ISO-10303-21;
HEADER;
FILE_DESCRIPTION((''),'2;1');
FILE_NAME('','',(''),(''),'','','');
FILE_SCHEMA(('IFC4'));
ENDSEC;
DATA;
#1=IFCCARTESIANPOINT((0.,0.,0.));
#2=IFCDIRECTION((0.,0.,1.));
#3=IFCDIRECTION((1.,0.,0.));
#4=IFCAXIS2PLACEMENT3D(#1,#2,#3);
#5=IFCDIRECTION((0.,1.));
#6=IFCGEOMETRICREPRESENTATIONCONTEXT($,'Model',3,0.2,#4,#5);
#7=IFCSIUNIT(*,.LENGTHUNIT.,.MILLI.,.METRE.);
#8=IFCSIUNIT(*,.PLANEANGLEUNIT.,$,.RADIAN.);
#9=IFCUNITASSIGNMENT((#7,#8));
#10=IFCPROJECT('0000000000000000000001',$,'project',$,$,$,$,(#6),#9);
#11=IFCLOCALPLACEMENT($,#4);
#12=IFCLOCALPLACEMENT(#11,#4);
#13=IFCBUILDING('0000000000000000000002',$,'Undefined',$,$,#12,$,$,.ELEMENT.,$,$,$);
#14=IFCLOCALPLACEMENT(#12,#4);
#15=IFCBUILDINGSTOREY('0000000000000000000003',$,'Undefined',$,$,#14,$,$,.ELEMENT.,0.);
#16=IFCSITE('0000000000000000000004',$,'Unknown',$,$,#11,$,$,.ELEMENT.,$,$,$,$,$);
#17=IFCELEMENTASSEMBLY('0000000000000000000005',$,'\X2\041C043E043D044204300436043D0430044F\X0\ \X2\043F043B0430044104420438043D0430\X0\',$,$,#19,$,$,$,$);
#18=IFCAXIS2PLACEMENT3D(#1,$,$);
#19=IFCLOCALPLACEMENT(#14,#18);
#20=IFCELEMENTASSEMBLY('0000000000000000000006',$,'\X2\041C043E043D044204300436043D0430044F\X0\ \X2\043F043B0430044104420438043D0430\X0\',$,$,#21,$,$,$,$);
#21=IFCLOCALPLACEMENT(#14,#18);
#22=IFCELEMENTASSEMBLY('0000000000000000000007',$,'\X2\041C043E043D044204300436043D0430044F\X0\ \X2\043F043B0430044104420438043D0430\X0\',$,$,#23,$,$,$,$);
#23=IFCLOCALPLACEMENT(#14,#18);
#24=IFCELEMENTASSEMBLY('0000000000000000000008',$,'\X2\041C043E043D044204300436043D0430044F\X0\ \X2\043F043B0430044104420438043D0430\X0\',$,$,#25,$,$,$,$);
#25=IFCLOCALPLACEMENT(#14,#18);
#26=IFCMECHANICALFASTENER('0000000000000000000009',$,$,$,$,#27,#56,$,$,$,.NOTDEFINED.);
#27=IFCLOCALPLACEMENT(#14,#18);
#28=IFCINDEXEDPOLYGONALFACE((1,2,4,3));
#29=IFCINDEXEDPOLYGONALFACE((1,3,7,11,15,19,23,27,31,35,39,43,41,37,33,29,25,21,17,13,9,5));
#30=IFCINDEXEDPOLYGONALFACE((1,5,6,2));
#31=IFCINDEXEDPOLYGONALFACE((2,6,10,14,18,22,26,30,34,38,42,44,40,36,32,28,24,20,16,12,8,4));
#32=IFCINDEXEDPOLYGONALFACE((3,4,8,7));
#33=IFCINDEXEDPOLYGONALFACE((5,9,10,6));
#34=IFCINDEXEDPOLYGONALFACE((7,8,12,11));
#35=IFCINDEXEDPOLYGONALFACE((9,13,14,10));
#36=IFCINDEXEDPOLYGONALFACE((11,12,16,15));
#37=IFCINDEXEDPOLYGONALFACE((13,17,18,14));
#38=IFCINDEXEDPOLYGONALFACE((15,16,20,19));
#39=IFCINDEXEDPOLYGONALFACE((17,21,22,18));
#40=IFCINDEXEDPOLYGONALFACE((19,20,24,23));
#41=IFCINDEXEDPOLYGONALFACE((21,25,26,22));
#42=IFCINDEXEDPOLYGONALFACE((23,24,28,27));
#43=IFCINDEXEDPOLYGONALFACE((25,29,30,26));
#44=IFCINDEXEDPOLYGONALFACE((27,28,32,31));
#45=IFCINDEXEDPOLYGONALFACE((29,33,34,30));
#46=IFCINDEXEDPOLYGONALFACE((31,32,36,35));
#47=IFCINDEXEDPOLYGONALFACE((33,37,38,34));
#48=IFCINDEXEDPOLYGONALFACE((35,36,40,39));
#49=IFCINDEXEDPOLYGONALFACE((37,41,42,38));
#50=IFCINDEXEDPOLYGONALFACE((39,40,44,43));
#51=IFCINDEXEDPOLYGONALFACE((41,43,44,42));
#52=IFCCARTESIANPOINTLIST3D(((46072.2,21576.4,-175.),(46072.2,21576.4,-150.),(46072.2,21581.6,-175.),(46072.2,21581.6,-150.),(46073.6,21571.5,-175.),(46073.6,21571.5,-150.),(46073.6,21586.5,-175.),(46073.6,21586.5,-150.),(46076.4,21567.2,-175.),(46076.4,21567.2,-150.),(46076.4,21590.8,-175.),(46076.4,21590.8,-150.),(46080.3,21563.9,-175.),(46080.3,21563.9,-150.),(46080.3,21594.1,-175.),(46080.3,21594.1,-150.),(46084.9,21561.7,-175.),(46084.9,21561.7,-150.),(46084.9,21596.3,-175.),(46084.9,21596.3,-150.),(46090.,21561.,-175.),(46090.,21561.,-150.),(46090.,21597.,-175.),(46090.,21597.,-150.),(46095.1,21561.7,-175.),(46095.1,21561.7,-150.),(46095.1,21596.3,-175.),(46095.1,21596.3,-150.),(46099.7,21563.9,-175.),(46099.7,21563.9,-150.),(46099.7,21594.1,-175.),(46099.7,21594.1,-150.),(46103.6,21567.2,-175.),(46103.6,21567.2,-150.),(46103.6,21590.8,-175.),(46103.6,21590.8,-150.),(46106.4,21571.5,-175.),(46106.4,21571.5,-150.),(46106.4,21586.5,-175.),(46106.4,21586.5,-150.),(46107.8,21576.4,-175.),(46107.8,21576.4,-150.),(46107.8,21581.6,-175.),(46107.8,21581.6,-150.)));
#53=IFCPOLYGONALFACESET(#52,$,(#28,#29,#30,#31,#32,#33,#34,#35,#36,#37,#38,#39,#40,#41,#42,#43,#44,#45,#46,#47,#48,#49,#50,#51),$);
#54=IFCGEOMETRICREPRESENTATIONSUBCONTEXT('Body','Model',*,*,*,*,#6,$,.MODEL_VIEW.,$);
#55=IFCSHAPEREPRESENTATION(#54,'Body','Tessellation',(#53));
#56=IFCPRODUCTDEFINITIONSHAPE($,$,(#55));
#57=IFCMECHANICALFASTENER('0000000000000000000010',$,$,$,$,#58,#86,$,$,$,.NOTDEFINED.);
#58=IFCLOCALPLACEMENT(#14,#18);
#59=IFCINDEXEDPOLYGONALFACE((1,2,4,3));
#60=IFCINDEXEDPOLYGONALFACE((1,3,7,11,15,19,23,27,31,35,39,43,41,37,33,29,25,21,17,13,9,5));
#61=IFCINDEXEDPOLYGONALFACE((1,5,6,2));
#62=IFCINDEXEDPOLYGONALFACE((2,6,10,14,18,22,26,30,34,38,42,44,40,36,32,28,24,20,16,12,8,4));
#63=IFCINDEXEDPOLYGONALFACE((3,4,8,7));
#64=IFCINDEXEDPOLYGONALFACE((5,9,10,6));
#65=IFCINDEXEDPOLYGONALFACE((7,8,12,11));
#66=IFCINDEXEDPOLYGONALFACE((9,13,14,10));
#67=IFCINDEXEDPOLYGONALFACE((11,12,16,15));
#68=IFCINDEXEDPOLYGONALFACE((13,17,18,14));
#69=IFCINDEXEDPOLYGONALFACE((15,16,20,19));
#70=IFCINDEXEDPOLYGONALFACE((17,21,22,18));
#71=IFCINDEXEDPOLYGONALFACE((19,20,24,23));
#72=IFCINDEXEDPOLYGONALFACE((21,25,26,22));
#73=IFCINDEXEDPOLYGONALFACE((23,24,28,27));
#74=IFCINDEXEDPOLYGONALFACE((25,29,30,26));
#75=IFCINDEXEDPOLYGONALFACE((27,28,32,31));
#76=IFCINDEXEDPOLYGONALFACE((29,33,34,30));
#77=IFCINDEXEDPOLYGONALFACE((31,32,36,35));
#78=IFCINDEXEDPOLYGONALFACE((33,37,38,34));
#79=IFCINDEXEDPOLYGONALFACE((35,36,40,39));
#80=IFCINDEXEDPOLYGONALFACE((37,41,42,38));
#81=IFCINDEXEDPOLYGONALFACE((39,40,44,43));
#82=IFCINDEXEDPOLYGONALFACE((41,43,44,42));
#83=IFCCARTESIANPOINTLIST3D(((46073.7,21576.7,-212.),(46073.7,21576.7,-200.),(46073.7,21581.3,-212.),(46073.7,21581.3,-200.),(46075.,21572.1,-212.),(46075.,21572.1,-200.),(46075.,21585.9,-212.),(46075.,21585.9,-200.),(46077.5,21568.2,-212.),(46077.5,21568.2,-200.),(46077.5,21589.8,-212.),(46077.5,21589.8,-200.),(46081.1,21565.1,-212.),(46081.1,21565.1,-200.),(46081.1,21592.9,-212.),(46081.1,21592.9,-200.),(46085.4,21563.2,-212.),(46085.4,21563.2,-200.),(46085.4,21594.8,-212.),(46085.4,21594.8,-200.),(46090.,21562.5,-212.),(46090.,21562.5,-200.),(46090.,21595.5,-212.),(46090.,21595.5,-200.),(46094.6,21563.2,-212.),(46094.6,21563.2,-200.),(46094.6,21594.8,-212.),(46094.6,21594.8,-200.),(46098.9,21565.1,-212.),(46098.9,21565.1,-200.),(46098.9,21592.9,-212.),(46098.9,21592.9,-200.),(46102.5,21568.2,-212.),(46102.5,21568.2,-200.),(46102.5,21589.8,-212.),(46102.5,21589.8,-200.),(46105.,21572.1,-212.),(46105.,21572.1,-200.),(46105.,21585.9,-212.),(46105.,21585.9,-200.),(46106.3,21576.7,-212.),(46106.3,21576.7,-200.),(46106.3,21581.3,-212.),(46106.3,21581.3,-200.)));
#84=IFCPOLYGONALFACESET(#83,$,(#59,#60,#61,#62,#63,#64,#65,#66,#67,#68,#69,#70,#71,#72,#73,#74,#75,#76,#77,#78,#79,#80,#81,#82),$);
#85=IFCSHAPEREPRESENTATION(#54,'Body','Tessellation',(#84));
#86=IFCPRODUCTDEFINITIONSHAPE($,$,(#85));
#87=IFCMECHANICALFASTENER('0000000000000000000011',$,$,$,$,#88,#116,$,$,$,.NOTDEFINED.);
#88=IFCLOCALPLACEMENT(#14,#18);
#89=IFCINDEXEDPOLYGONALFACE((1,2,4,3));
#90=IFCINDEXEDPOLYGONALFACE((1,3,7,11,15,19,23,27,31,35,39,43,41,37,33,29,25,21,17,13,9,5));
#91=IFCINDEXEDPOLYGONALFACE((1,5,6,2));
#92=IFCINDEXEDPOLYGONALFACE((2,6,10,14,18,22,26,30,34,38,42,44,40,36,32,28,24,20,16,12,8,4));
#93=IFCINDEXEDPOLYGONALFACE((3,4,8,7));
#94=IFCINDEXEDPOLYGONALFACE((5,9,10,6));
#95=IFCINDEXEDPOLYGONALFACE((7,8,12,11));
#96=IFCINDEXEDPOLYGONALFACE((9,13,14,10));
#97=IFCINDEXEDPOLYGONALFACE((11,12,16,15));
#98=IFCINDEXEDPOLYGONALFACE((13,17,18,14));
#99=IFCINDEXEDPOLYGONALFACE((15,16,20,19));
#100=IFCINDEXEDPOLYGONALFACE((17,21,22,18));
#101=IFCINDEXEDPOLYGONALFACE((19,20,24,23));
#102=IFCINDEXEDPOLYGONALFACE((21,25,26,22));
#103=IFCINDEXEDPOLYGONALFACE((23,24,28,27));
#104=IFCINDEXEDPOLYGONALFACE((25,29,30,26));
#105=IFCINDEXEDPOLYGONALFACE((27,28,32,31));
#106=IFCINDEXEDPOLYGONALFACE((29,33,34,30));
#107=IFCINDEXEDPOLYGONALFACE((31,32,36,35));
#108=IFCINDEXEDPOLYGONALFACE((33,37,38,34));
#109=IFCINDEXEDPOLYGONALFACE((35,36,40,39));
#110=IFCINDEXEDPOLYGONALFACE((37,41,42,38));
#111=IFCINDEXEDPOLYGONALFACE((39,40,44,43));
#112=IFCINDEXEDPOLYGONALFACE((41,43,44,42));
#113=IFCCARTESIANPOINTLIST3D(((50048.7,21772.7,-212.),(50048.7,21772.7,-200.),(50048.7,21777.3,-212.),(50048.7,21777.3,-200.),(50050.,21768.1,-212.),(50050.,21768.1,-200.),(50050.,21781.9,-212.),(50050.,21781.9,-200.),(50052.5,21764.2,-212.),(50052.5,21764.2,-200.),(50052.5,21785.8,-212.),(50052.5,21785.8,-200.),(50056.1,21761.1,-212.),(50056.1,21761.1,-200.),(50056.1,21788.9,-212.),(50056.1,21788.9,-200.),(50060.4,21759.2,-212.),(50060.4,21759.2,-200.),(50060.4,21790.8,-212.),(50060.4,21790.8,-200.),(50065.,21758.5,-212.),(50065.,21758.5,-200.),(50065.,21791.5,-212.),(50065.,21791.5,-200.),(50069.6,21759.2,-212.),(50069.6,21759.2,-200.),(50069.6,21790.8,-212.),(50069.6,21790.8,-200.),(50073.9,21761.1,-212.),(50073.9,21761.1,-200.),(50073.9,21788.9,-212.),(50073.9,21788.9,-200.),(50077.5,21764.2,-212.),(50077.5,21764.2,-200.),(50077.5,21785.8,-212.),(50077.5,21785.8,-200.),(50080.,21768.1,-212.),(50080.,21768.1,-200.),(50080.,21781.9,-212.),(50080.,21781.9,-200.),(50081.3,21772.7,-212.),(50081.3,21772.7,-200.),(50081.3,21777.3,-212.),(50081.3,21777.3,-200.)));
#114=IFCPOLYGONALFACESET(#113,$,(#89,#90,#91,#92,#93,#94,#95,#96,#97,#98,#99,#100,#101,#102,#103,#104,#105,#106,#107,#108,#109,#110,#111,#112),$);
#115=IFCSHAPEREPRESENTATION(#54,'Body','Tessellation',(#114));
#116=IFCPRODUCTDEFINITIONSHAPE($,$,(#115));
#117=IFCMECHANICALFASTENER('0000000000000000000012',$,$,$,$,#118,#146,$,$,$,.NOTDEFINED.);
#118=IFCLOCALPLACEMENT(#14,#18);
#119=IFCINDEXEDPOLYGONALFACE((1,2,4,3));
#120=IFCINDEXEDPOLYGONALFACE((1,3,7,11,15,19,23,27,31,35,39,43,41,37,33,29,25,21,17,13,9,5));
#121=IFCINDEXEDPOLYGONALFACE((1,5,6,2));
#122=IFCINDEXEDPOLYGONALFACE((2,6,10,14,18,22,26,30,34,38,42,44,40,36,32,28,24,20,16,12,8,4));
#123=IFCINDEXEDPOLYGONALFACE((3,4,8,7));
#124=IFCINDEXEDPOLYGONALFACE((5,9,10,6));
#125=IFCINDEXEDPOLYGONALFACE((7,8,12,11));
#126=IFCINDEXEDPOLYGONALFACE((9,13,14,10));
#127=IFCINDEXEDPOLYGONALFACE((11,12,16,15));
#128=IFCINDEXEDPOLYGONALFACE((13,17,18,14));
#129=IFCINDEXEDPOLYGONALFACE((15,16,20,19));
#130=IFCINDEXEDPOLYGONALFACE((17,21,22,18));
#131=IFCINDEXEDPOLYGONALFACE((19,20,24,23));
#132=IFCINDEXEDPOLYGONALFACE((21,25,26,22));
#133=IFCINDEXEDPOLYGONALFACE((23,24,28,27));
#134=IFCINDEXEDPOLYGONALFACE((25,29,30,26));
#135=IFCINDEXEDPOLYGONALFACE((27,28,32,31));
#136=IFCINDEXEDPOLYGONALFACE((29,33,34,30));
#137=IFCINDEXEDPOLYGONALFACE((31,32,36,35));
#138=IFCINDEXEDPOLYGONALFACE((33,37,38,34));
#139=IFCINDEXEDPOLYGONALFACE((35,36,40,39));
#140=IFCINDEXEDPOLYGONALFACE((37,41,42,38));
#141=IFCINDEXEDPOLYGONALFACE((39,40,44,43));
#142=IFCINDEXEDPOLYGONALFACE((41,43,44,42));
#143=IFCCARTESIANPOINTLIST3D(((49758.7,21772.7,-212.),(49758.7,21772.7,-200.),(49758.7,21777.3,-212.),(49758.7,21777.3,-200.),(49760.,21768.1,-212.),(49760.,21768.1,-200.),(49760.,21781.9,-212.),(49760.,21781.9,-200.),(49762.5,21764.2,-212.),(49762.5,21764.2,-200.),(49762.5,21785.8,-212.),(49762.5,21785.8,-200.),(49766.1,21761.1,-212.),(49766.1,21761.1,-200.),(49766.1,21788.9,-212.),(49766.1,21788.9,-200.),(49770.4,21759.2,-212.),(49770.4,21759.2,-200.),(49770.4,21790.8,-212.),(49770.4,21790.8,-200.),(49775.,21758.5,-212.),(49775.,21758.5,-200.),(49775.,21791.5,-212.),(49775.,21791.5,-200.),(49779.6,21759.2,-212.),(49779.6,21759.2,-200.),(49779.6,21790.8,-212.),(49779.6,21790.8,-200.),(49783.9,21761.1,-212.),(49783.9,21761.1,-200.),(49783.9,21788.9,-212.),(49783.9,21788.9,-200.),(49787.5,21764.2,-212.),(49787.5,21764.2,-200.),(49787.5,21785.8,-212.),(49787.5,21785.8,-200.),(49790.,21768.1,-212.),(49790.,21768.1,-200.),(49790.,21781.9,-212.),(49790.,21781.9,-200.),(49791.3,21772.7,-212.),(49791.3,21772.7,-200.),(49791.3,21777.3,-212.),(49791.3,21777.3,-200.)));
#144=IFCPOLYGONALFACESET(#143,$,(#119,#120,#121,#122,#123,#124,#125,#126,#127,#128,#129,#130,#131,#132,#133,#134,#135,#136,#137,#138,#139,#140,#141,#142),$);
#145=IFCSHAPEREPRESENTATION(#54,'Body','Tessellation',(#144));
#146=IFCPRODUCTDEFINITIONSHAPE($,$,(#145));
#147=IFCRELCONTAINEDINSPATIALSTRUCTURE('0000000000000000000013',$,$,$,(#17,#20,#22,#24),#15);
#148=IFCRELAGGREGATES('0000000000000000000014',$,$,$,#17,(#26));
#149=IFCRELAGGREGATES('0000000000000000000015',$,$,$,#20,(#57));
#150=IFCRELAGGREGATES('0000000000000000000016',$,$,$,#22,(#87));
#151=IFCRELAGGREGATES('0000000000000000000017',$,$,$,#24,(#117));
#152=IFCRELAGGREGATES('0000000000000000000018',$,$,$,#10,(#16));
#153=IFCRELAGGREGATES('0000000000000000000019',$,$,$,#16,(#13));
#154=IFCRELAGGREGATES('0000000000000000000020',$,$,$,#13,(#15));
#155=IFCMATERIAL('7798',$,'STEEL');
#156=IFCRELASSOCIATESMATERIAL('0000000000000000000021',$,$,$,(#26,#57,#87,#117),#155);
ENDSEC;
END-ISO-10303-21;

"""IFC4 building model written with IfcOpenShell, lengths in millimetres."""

from ifc_helpers import new_model, si_unit, direction, frame, origin_with_axes, place, context, subcontext, project, spatial, arc, indexed_curve, outline, extrude, source, transform, mapped, material, element, aggregate, save


model = new_model("IFC4")

# Units and contexts
model_context = context("Model", 3, precision=0.2, world=origin_with_axes(), true_north=direction((0.0, 1.0)))
body_context = subcontext(model_context, "Body", "Model", "MODEL_VIEW")
ifc_project = project(units=[si_unit("LENGTHUNIT", "METRE", prefix="MILLI"), si_unit("PLANEANGLEUNIT", "RADIAN")], contexts=[model_context])

# Site, building, storey
site_placement = place(None, origin_with_axes())
site = spatial("IfcSite", under=ifc_project, at=site_placement, Name="Unknown", CompositionType="ELEMENT")
building_placement = place(site_placement, origin_with_axes())
building = spatial("IfcBuilding", under=site, at=building_placement, Name="Undefined", CompositionType="ELEMENT")
storey_placement = place(building_placement, origin_with_axes())
storey = spatial("IfcBuildingStorey", under=building, at=storey_placement, Name="Undefined", CompositionType="ELEMENT", Elevation=0.0)

# Element assemblies
assembly_1_placement = place(storey_placement, frame((46140.0, 21579.0, -162.5), z_axis=(0.0, 0.0, -1.0), x_axis=(-1.0, 0.0, 0.0)))
assembly_1 = element("IfcElementAssembly", 1, at=assembly_1_placement, inside=storey, Name="Монтажная пластина")
assembly_2_placement = place(storey_placement, frame((46140.0, 21579.0, -206.0), z_axis=(0.0, 0.0, -1.0), x_axis=(-1.0, 0.0, 0.0)))
assembly_2 = element("IfcElementAssembly", 2, at=assembly_2_placement, inside=storey, Name="Монтажная пластина")
assembly_3_placement = place(storey_placement, frame((50015.0, 21775.0, -206.0), z_axis=(0.0, 0.0, -1.0), x_axis=(1.0, 0.0, 0.0)))
assembly_3 = element("IfcElementAssembly", 3, at=assembly_3_placement, inside=storey, Name="Монтажная пластина")
assembly_4_placement = place(storey_placement, frame((49725.0, 21775.0, -206.0), z_axis=(0.0, 0.0, -1.0), x_axis=(1.0, 0.0, 0.0)))
assembly_4 = element("IfcElementAssembly", 4, at=assembly_4_placement, inside=storey, Name="Монтажная пластина")

# Mechanical fasteners
ifc_material_1 = material(Name="7798", Category="STEEL")
shared_shape_1 = source(origin_with_axes(), body_context, "Body", "SweptSolid", [
    extrude(outline(indexed_curve([(18.0, 0.0), (0.0, 18.0), (-18.0, 0.0), (0.0, -18.0)], segments=[arc(1, 2, 3), arc(3, 4, 1)])), frame((0.0, 0.0, 0.0), z_axis=(0.0, 0.0, -1.0), x_axis=(0.0, 1.0, 0.0)), (0.0, 0.0, 1.0), 25.0),
])
mechanical_fastener_1_placement = place(assembly_1_placement, frame((50.0, 0.0, 12.5), z_axis=(0.0, 0.0, 1.0), x_axis=(1.0, 0.0, 0.0)))
mechanical_fastener_1 = element("IfcMechanicalFastener", 5, at=mechanical_fastener_1_placement, material=ifc_material_1, PredefinedType="NOTDEFINED", context=body_context, shape_type="MappedRepresentation", body=[
    mapped(shared_shape_1, transform((0.0, 0.0, 0.0))),
])
aggregate(assembly_1, [mechanical_fastener_1])
shared_shape_2 = source(origin_with_axes(), body_context, "Body", "SweptSolid", [
    extrude(outline(indexed_curve([(16.5, 0.0), (0.0, 16.5), (-16.5, 0.0), (0.0, -16.5)], segments=[arc(1, 2, 3), arc(3, 4, 1)])), frame((0.0, 0.0, 12.0), z_axis=(0.0, 0.0, -1.0), x_axis=(0.0, 1.0, 0.0)), (0.0, 0.0, 1.0), 12.0),
])
mechanical_fastener_2_placement = place(assembly_2_placement, frame((50.0, 0.0, -6.0), z_axis=(0.0, 0.0, 1.0), x_axis=(1.0, 0.0, 0.0)))
mechanical_fastener_2 = element("IfcMechanicalFastener", 6, at=mechanical_fastener_2_placement, material=ifc_material_1, PredefinedType="NOTDEFINED", context=body_context, shape_type="MappedRepresentation", body=[
    mapped(shared_shape_2, transform((0.0, 0.0, 0.0))),
])
aggregate(assembly_2, [mechanical_fastener_2])
mechanical_fastener_3_placement = place(assembly_3_placement, frame((50.0, 0.0, -6.0), z_axis=(0.0, 0.0, 1.0), x_axis=(1.0, 0.0, 0.0)))
mechanical_fastener_3 = element("IfcMechanicalFastener", 7, at=mechanical_fastener_3_placement, material=ifc_material_1, PredefinedType="NOTDEFINED", context=body_context, shape_type="MappedRepresentation", body=[
    mapped(shared_shape_2, transform((0.0, 0.0, 0.0))),
])
aggregate(assembly_3, [mechanical_fastener_3])
mechanical_fastener_4_placement = place(assembly_4_placement, frame((50.0, 0.0, -6.0), z_axis=(0.0, 0.0, 1.0), x_axis=(1.0, 0.0, 0.0)))
mechanical_fastener_4 = element("IfcMechanicalFastener", 8, at=mechanical_fastener_4_placement, material=ifc_material_1, PredefinedType="NOTDEFINED", context=body_context, shape_type="MappedRepresentation", body=[
    mapped(shared_shape_2, transform((0.0, 0.0, 0.0))),
])
aggregate(assembly_4, [mechanical_fastener_4])

save(model, "model.ifc")
